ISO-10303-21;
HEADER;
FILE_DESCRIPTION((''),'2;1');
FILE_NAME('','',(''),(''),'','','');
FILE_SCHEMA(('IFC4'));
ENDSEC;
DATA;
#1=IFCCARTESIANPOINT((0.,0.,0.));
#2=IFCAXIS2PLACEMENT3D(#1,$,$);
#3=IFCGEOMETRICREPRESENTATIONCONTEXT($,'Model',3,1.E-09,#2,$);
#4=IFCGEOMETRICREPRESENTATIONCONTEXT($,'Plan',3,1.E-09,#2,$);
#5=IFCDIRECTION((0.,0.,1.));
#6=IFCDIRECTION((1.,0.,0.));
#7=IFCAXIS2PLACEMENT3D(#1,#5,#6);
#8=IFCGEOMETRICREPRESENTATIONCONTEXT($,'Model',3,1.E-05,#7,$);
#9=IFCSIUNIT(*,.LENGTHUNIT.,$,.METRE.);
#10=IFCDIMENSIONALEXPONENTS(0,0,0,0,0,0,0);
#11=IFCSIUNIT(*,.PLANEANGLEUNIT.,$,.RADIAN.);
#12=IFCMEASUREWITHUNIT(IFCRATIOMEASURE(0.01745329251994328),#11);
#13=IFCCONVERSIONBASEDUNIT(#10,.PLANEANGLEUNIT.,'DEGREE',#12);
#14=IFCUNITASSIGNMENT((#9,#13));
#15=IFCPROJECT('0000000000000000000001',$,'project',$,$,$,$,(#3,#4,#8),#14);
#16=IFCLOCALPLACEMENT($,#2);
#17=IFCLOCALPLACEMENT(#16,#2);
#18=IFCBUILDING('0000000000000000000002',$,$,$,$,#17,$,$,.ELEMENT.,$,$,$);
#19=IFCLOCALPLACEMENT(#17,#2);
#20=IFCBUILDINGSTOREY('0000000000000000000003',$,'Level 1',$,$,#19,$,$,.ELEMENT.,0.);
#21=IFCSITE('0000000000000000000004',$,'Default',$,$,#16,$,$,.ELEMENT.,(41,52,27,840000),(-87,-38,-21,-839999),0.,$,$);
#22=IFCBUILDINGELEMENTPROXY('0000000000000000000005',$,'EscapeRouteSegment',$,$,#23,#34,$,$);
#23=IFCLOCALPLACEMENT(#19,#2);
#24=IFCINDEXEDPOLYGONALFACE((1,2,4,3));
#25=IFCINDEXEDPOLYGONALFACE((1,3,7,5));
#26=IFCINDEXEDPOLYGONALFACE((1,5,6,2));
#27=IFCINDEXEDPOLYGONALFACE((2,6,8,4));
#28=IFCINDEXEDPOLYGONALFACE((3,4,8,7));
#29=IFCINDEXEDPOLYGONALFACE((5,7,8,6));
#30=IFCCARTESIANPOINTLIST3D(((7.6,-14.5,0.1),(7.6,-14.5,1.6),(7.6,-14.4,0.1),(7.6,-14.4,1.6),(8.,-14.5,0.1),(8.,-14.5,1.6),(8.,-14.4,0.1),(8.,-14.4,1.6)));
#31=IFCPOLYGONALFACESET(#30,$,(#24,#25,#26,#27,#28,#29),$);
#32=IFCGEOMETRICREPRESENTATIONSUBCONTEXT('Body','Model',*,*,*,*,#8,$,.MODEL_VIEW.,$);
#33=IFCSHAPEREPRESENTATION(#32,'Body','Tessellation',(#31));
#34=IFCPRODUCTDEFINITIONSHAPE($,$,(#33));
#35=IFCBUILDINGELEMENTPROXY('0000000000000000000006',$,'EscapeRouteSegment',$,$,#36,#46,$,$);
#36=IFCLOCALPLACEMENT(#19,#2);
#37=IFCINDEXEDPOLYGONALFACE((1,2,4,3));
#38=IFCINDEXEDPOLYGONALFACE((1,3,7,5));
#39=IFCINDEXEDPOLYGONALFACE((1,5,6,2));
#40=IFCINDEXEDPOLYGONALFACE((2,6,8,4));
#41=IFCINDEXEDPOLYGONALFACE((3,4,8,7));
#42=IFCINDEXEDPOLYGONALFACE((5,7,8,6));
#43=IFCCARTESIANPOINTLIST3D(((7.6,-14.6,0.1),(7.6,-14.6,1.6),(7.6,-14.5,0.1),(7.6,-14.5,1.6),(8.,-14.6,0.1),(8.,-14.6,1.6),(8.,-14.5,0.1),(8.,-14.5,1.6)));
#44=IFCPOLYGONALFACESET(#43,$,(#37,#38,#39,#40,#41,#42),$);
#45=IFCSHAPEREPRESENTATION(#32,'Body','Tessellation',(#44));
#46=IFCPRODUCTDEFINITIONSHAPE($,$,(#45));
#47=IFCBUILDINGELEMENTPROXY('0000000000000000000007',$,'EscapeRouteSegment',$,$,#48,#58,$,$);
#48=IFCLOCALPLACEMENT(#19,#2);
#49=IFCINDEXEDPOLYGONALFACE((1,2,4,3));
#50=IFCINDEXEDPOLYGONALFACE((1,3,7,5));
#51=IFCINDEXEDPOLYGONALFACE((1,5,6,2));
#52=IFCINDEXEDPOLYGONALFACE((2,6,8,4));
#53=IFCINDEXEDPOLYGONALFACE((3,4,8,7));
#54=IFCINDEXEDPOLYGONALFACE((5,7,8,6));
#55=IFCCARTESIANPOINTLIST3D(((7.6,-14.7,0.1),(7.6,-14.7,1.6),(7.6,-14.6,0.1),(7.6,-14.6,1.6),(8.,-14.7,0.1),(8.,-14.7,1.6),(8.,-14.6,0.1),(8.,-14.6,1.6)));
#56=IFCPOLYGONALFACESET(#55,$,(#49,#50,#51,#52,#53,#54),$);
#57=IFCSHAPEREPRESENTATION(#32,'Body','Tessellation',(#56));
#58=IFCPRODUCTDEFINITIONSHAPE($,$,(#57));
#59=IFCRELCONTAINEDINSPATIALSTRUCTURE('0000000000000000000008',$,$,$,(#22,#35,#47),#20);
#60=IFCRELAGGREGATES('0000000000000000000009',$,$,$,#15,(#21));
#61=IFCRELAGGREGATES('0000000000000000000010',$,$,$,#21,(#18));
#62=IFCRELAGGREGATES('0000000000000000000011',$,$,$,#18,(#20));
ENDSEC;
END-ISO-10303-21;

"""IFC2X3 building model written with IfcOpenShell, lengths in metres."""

from ifc_helpers import new_model, entity, si_unit, converted_unit, frame, origin, origin_with_axes, place, context, subcontext, project, spatial, polyline, outline, extrude, element, save


model = new_model("IFC2X3")

# Units and contexts
model_context_1 = context("Model", 3, precision=1e-09, world=origin())
plan_context = context("Plan", 3, precision=1e-09, world=origin())
model_context_2 = context("Model", 3, precision=1e-05, world=origin_with_axes())
body_context = subcontext(model_context_2, "Body", "Model", "MODEL_VIEW")
ifc_project = project(units=[si_unit("LENGTHUNIT", "METRE"), converted_unit("PLANEANGLEUNIT", "DEGREE", entity("IfcRatioMeasure", 0.01745329251994328), si_unit("PLANEANGLEUNIT", "RADIAN"), dimensions=[0, 0, 0, 0, 0, 0, 0])], contexts=[model_context_1, plan_context, model_context_2])

# Site, building, storey
site_placement = place(None, origin())
site = spatial("IfcSite", under=ifc_project, at=site_placement, Name="Default", CompositionType="ELEMENT", RefLatitude=(41, 52, 27, 840000), RefLongitude=(-87, -38, -21, -839999), RefElevation=0.0)
building_placement = place(site_placement, origin())
building = spatial("IfcBuilding", under=site, at=building_placement, CompositionType="ELEMENT")
storey_placement = place(building_placement, origin())
storey = spatial("IfcBuildingStorey", under=building, at=storey_placement, Name="Level 1", CompositionType="ELEMENT", Elevation=0.0)

# Building element proxies
for number, where, z_axis, x_axis, name in (
    (1, (7.8, -14.4, 0.1), (0.0, 0.0, 1.0), (0.0, -1.0, 0.0), "EscapeRouteSegment"),
    (2, (7.8, -14.5, 0.1), (0.0, 0.0, 1.0), (0.0, -1.0, 0.0), "EscapeRouteSegment"),
):
    element("IfcBuildingElementProxy", number, at=place(storey_placement, frame(where, z_axis=z_axis, x_axis=x_axis)), inside=storey, Name=name, context=body_context, shape_type="SweptSolid", body=[
        extrude(outline(polyline([(0.0, -0.2), (0.0, 0.2), (0.1, 0.2), (0.1, -0.2), (0.0, -0.2)])), origin_with_axes(), (0.0, 0.0, 1.0), 1.5),
    ])
proxy_1_placement = place(storey_placement, frame((7.8, -14.6, 0.1), z_axis=(0.0, 0.0, 1.0), x_axis=(0.0, -1.0, 0.0)))
element("IfcBuildingElementProxy", 3, at=proxy_1_placement, inside=storey, Name="EscapeRouteSegment", context=body_context, shape_type="SweptSolid", body=[
    extrude(outline(polyline([(0.0, -0.2), (0.0, 0.2), (0.1, 0.2), (0.1, -0.2), (0.0, -0.2)])), origin_with_axes(), (0.0, 0.0, 1.0), 1.5),
])

save(model, "model.ifc")
